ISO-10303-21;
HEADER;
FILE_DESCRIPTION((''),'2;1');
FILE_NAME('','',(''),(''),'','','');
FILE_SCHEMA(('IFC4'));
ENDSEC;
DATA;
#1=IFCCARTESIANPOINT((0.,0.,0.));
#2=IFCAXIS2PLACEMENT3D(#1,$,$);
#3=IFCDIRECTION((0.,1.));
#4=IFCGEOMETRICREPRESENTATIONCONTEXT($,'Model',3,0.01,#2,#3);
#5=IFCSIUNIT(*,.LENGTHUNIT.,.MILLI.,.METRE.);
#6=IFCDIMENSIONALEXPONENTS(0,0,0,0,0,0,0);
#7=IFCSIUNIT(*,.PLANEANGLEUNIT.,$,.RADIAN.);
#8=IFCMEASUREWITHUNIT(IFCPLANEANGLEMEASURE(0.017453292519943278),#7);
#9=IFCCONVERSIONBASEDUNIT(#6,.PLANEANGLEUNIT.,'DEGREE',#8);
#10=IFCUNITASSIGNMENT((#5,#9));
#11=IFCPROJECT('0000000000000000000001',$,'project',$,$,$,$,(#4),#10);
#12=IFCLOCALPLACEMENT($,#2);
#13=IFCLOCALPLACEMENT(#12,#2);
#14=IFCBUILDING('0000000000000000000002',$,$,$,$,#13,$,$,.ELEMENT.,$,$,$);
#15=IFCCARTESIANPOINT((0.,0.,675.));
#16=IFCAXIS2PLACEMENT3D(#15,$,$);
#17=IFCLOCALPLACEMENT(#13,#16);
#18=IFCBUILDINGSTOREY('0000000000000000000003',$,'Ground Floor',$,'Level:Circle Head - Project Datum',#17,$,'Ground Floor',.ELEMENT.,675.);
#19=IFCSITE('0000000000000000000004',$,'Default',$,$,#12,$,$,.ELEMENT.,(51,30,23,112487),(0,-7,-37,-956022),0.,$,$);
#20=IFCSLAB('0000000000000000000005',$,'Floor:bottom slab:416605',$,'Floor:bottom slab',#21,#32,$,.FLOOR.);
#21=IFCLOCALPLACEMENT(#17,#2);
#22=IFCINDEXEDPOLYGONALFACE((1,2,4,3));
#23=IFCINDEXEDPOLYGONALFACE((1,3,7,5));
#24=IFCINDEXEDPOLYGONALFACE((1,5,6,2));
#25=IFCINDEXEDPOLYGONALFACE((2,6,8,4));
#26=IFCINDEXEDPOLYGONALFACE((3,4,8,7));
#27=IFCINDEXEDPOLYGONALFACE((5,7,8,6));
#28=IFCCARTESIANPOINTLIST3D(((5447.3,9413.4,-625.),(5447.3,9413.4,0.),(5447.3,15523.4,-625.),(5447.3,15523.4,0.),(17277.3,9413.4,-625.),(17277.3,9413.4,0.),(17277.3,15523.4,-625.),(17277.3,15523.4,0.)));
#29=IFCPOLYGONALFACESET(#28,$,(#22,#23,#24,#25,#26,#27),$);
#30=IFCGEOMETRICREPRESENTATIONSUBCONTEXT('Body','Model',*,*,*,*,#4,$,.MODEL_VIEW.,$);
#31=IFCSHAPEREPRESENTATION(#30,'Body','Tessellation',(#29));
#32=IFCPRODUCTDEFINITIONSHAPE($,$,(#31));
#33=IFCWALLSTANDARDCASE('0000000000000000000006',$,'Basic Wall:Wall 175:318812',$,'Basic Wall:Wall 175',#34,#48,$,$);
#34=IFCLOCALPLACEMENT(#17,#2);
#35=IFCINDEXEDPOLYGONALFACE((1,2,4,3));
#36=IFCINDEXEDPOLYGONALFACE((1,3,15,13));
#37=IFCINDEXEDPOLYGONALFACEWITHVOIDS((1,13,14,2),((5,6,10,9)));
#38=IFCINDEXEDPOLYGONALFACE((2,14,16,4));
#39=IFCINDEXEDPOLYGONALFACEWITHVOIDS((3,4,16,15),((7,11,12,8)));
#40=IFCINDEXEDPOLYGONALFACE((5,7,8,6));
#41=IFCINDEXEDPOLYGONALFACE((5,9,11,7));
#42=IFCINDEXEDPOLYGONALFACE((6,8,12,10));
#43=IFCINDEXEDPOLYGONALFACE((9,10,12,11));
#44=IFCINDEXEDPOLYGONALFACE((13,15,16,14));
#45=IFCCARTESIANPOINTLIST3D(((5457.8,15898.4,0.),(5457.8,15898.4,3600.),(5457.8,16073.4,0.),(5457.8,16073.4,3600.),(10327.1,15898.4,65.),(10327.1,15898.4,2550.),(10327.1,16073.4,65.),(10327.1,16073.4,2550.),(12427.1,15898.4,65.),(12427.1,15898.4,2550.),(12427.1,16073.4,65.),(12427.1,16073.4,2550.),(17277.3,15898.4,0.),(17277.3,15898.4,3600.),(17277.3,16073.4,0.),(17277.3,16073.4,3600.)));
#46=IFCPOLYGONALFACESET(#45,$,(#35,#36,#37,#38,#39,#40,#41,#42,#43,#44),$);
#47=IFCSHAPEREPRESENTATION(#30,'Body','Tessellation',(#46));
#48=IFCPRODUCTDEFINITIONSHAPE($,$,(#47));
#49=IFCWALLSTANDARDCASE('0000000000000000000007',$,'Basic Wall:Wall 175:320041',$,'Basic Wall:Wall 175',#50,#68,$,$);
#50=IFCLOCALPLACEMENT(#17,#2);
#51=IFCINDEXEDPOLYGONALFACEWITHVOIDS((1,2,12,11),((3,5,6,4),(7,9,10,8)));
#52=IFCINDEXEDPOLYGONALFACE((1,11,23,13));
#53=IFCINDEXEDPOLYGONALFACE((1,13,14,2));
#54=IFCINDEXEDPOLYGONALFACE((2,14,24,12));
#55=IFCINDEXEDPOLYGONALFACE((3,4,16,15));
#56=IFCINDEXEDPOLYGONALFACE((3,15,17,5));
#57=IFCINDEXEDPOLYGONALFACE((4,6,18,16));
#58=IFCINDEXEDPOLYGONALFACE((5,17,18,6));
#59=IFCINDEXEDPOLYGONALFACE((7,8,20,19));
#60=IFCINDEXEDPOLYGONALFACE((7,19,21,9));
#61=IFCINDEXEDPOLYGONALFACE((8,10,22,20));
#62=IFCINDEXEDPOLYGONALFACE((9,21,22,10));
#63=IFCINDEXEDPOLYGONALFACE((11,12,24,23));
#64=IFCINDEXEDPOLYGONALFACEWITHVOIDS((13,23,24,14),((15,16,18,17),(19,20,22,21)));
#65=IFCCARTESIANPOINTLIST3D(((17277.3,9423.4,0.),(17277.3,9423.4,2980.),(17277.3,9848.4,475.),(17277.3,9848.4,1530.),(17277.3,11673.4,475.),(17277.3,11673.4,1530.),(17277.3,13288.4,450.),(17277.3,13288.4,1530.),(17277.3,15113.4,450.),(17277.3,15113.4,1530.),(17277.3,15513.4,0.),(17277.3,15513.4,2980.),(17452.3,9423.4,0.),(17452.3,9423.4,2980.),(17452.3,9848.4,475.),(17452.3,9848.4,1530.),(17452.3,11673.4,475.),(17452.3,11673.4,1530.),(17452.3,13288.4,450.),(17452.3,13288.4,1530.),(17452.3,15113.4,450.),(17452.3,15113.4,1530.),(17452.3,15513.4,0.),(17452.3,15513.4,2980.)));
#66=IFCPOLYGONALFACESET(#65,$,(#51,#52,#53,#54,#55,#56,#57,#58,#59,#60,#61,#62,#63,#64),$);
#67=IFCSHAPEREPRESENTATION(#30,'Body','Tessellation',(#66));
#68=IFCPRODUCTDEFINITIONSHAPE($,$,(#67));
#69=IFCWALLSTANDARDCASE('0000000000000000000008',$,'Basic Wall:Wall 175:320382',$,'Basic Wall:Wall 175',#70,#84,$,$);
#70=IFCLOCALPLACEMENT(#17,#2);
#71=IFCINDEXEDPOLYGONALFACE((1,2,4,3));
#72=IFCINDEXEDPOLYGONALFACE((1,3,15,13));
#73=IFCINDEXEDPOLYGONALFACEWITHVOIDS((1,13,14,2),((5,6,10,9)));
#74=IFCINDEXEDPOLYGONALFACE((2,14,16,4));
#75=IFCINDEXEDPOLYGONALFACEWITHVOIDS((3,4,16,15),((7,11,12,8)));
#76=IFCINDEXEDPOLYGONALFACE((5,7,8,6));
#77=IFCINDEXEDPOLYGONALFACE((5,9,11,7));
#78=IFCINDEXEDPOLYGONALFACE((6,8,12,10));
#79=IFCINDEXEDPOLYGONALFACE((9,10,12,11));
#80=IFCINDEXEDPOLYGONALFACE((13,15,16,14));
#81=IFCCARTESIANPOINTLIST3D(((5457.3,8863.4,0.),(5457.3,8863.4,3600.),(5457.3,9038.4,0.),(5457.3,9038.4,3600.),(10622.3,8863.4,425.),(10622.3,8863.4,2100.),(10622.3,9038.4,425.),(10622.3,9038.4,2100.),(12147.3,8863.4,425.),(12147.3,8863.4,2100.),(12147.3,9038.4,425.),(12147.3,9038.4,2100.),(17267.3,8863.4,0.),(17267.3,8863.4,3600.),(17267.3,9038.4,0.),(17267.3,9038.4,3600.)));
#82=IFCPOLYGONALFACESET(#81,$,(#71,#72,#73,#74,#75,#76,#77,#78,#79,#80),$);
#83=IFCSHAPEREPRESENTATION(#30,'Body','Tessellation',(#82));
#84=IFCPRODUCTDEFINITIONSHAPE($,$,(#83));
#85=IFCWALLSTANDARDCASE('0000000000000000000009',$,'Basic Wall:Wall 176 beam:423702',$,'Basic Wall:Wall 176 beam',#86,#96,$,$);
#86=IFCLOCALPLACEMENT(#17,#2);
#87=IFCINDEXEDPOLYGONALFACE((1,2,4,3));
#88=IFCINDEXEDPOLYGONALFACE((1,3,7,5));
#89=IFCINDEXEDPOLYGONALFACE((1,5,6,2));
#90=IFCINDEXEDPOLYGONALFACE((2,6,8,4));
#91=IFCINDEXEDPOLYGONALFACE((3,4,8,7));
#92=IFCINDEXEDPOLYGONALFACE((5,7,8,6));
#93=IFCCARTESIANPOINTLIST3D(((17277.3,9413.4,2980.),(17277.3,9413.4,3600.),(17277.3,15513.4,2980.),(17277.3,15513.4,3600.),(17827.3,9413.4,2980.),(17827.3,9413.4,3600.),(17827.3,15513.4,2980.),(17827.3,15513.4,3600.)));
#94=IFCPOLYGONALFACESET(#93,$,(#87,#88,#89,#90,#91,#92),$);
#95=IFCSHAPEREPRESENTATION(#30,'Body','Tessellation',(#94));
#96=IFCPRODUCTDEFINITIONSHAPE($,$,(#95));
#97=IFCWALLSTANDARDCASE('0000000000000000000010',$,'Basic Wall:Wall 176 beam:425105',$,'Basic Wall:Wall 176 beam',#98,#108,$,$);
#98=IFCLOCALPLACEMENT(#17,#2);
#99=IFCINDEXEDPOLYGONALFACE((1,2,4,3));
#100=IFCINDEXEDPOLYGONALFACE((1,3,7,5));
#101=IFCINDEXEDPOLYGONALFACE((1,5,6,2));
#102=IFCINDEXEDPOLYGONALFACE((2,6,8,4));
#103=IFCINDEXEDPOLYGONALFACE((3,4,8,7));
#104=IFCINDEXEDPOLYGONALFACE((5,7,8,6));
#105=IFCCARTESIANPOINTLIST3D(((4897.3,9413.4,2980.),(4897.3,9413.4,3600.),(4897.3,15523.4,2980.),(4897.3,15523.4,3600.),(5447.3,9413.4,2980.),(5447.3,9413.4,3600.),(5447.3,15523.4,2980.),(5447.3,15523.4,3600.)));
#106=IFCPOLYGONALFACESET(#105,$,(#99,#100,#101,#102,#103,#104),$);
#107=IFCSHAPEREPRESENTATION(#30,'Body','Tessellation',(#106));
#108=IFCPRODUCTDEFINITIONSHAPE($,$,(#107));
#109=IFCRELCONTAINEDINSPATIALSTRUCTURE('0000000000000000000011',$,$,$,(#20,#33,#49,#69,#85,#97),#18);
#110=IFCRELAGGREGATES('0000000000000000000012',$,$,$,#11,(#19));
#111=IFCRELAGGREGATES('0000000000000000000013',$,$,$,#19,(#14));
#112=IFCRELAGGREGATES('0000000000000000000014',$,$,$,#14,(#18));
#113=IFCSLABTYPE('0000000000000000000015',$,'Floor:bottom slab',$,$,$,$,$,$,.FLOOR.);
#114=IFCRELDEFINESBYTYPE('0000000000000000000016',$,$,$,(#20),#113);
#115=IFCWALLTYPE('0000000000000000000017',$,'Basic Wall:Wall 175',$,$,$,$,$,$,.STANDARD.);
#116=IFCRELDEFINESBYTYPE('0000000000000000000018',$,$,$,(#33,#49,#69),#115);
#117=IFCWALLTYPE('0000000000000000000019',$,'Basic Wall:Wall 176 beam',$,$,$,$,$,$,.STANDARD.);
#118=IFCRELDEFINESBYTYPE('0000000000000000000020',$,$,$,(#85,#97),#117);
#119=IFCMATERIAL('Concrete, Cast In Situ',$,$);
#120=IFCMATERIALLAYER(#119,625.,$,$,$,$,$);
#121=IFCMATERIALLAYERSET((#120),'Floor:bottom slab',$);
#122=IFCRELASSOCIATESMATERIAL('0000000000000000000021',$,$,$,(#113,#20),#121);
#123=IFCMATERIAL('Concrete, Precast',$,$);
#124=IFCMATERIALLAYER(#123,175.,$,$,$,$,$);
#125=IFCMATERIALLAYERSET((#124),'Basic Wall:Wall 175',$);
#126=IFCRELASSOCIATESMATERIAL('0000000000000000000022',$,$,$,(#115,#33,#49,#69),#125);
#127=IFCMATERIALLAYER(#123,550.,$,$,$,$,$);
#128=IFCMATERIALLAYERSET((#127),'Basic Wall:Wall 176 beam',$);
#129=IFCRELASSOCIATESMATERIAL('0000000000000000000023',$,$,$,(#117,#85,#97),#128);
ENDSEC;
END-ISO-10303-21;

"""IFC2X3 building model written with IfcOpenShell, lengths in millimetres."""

from ifc_helpers import new_model, entity, si_unit, converted_unit, direction, frame, frame_2d, origin, origin_2d_with_axis, place, context, subcontext, project, spatial, rectangle, extrude, material, layer, layer_set, layer_usage, type_object, element, save


model = new_model("IFC2X3")

# Units and contexts
model_context = context("Model", 3, precision=0.01, world=origin(), true_north=direction((0.0, 1.0)))
body_context = subcontext(model_context, "Body", "Model", "MODEL_VIEW")
ifc_project = project(units=[si_unit("LENGTHUNIT", "METRE", prefix="MILLI"), converted_unit("PLANEANGLEUNIT", "DEGREE", entity("IfcPlaneAngleMeasure", 0.017453292519943278), si_unit("PLANEANGLEUNIT", "RADIAN"), dimensions=[0, 0, 0, 0, 0, 0, 0])], contexts=[model_context])

# Site, building, storey
site_placement = place(None, origin())
site = spatial("IfcSite", under=ifc_project, at=site_placement, Name="Default", CompositionType="ELEMENT", RefLatitude=(51, 30, 23, 112487), RefLongitude=(0, -7, -37, -956022), RefElevation=0.0)
building_placement = place(site_placement, origin())
building = spatial("IfcBuilding", under=site, at=building_placement, CompositionType="ELEMENT")
storey_placement = place(building_placement, frame((0.0, 0.0, 675.0)))
storey = spatial("IfcBuildingStorey", under=building, at=storey_placement, Name="Ground Floor", ObjectType="Level:Circle Head - Project Datum", LongName="Ground Floor", CompositionType="ELEMENT", Elevation=675.0)

# Shared definitions
ifc_material_1 = material(Name="Concrete, Precast")

# Slab
ifc_material_2 = material(Name="Concrete, Cast In Situ")
ifc_layer_1 = layer(ifc_material_2, 625.0)
ifc_layer_set_1 = layer_set([ifc_layer_1], Name="Floor:bottom slab")
ifc_layer_usage_1 = layer_usage(ifc_layer_set_1, "AXIS3", "POSITIVE", 0.0)
slab_type = type_object("IfcSlabType", Name="Floor:bottom slab", PredefinedType="FLOOR", material=ifc_layer_set_1)
slab_placement = place(storey_placement, origin())
element("IfcSlab", 1, at=slab_placement, inside=storey, type_object=slab_type, material=ifc_layer_usage_1, Name="Floor:bottom slab:416605", ObjectType="Floor:bottom slab", PredefinedType="FLOOR", context=body_context, shape_type="SweptSolid", body=[
    extrude(rectangle(XDim=6110.0, YDim=11830.0, at=frame_2d((0.0, 0.0), x_axis=(1.0, 0.0))), frame((11362.3, 12468.4, 0.0), z_axis=(0.0, 0.0, -1.0), x_axis=(0.0, 1.0, 0.0)), (0.0, 0.0, 1.0), 625.0),
])

# Wall, opening
ifc_layer_2 = layer(ifc_material_1, 175.0)
ifc_layer_set_2 = layer_set([ifc_layer_2], Name="Basic Wall:Wall 175")
ifc_layer_usage_2 = layer_usage(ifc_layer_set_2, "AXIS2", "NEGATIVE", 87.5)
wall_type_1 = type_object("IfcWallType", Name="Basic Wall:Wall 175", PredefinedType="STANDARD", material=ifc_layer_set_2)
wall_1_placement = place(storey_placement, frame((5457.8, 15985.9, 0.0)))
wall_1 = element("IfcWallStandardCase", 2, at=wall_1_placement, inside=storey, type_object=wall_type_1, material=ifc_layer_usage_2, Name="Basic Wall:Wall 175:318812", ObjectType="Basic Wall:Wall 175", context=body_context, shape_type="SweptSolid", body=[
    extrude(rectangle(XDim=11819.5, YDim=175.0, at=frame_2d((5909.7, 0.0), x_axis=(-1.0, 0.0))), origin(), (0.0, 0.0, 1.0), 3600.0),
])
opening_1_placement = place(wall_1_placement, origin())
element("IfcOpeningElement", 3, at=opening_1_placement, cuts=wall_1, ObjectType="Opening", context=body_context, shape_type="SweptSolid", body=[
    extrude(rectangle(XDim=2485.0, YDim=2100.0, at=origin_2d_with_axis()), frame((5919.3, 87.5, 1307.5), z_axis=(0.0, -1.0, 0.0), x_axis=(0.0, 0.0, -1.0)), (0.0, 0.0, 1.0), 175.0),
])

# Wall, openings
ifc_layer_usage_3 = layer_usage(ifc_layer_set_2, "AXIS2", "NEGATIVE", 87.5)
wall_2_placement = place(storey_placement, frame((17364.8, 15513.4, 0.0), z_axis=(0.0, 0.0, 1.0), x_axis=(0.0, -1.0, 0.0)))
wall_2 = element("IfcWallStandardCase", 4, at=wall_2_placement, inside=storey, type_object=wall_type_1, material=ifc_layer_usage_3, Name="Basic Wall:Wall 175:320041", ObjectType="Basic Wall:Wall 175", context=body_context, shape_type="SweptSolid", body=[
    extrude(rectangle(XDim=6090.0, YDim=175.0, at=frame_2d((3045.0, 0.0), x_axis=(-1.0, 0.0))), origin(), (0.0, 0.0, 1.0), 2980.0),
])
opening_2_placement = place(wall_2_placement, origin())
element("IfcOpeningElement", 5, at=opening_2_placement, cuts=wall_2, ObjectType="Opening", context=body_context, shape_type="SweptSolid", body=[
    extrude(rectangle(XDim=1055.0, YDim=1825.0, at=frame_2d((0.0, 0.0), x_axis=(1.0, 0.0))), frame((4752.5, 87.5, 1002.5), z_axis=(0.0, -1.0, 0.0), x_axis=(0.0, 0.0, -1.0)), (0.0, 0.0, 1.0), 175.0),
])
opening_3_placement = place(wall_2_placement, origin())
element("IfcOpeningElement", 6, at=opening_3_placement, cuts=wall_2, ObjectType="Opening", context=body_context, shape_type="SweptSolid", body=[
    extrude(rectangle(XDim=1080.0, YDim=1825.0, at=frame_2d((0.0, 0.0), x_axis=(1.0, 0.0))), frame((1312.5, 87.5, 990.0), z_axis=(0.0, 1.0, 0.0), x_axis=(0.0, 0.0, -1.0)), (0.0, 0.0, -1.0), 175.0),
])

# Wall, opening
ifc_layer_usage_4 = layer_usage(ifc_layer_set_2, "AXIS2", "NEGATIVE", 87.5)
wall_3_placement = place(storey_placement, frame((17267.3, 8950.9, 0.0), z_axis=(0.0, 0.0, 1.0), x_axis=(-1.0, 0.0, 0.0)))
wall_3 = element("IfcWallStandardCase", 7, at=wall_3_placement, inside=storey, type_object=wall_type_1, material=ifc_layer_usage_4, Name="Basic Wall:Wall 175:320382", ObjectType="Basic Wall:Wall 175", context=body_context, shape_type="SweptSolid", body=[
    extrude(rectangle(XDim=11810.0, YDim=175.0, at=frame_2d((5905.0, 0.0), x_axis=(-1.0, 0.0))), origin(), (0.0, 0.0, 1.0), 3600.0),
])
opening_4_placement = place(wall_3_placement, origin())
element("IfcOpeningElement", 8, at=opening_4_placement, cuts=wall_3, ObjectType="Opening", context=body_context, shape_type="SweptSolid", body=[
    extrude(rectangle(XDim=1675.0, YDim=1525.0, at=frame_2d((0.0, 0.0), x_axis=(1.0, 0.0))), frame((5882.5, 87.5, 1262.5), z_axis=(0.0, -1.0, 0.0), x_axis=(0.0, 0.0, -1.0)), (0.0, 0.0, 1.0), 175.0),
])

# Walls
ifc_layer_3 = layer(ifc_material_1, 550.0)
ifc_layer_set_3 = layer_set([ifc_layer_3], Name="Basic Wall:Wall 176 beam")
ifc_layer_usage_5 = layer_usage(ifc_layer_set_3, "AXIS2", "NEGATIVE", 275.0)
wall_type_2 = type_object("IfcWallType", Name="Basic Wall:Wall 176 beam", PredefinedType="STANDARD", material=ifc_layer_set_3)
wall_4_placement = place(storey_placement, frame((17552.3, 15513.4, 2980.0), z_axis=(0.0, 0.0, 1.0), x_axis=(0.0, -1.0, 0.0)))
element("IfcWallStandardCase", 9, at=wall_4_placement, inside=storey, type_object=wall_type_2, material=ifc_layer_usage_5, Name="Basic Wall:Wall 176 beam:423702", ObjectType="Basic Wall:Wall 176 beam", context=body_context, shape_type="SweptSolid", body=[
    extrude(rectangle(XDim=6100.0, YDim=550.0, at=frame_2d((3050.0, 0.0), x_axis=(-1.0, 0.0))), origin(), (0.0, 0.0, 1.0), 620.0),
])
ifc_layer_usage_6 = layer_usage(ifc_layer_set_3, "AXIS2", "NEGATIVE", 275.0)
wall_5_placement = place(storey_placement, frame((5172.3, 15523.4, 2980.0), z_axis=(0.0, 0.0, 1.0), x_axis=(0.0, -1.0, 0.0)))
element("IfcWallStandardCase", 10, at=wall_5_placement, inside=storey, type_object=wall_type_2, material=ifc_layer_usage_6, Name="Basic Wall:Wall 176 beam:425105", ObjectType="Basic Wall:Wall 176 beam", context=body_context, shape_type="SweptSolid", body=[
    extrude(rectangle(XDim=6110.0, YDim=550.0, at=frame_2d((3055.0, 0.0), x_axis=(-1.0, 0.0))), origin(), (0.0, 0.0, 1.0), 620.0),
])

save(model, "model.ifc")
